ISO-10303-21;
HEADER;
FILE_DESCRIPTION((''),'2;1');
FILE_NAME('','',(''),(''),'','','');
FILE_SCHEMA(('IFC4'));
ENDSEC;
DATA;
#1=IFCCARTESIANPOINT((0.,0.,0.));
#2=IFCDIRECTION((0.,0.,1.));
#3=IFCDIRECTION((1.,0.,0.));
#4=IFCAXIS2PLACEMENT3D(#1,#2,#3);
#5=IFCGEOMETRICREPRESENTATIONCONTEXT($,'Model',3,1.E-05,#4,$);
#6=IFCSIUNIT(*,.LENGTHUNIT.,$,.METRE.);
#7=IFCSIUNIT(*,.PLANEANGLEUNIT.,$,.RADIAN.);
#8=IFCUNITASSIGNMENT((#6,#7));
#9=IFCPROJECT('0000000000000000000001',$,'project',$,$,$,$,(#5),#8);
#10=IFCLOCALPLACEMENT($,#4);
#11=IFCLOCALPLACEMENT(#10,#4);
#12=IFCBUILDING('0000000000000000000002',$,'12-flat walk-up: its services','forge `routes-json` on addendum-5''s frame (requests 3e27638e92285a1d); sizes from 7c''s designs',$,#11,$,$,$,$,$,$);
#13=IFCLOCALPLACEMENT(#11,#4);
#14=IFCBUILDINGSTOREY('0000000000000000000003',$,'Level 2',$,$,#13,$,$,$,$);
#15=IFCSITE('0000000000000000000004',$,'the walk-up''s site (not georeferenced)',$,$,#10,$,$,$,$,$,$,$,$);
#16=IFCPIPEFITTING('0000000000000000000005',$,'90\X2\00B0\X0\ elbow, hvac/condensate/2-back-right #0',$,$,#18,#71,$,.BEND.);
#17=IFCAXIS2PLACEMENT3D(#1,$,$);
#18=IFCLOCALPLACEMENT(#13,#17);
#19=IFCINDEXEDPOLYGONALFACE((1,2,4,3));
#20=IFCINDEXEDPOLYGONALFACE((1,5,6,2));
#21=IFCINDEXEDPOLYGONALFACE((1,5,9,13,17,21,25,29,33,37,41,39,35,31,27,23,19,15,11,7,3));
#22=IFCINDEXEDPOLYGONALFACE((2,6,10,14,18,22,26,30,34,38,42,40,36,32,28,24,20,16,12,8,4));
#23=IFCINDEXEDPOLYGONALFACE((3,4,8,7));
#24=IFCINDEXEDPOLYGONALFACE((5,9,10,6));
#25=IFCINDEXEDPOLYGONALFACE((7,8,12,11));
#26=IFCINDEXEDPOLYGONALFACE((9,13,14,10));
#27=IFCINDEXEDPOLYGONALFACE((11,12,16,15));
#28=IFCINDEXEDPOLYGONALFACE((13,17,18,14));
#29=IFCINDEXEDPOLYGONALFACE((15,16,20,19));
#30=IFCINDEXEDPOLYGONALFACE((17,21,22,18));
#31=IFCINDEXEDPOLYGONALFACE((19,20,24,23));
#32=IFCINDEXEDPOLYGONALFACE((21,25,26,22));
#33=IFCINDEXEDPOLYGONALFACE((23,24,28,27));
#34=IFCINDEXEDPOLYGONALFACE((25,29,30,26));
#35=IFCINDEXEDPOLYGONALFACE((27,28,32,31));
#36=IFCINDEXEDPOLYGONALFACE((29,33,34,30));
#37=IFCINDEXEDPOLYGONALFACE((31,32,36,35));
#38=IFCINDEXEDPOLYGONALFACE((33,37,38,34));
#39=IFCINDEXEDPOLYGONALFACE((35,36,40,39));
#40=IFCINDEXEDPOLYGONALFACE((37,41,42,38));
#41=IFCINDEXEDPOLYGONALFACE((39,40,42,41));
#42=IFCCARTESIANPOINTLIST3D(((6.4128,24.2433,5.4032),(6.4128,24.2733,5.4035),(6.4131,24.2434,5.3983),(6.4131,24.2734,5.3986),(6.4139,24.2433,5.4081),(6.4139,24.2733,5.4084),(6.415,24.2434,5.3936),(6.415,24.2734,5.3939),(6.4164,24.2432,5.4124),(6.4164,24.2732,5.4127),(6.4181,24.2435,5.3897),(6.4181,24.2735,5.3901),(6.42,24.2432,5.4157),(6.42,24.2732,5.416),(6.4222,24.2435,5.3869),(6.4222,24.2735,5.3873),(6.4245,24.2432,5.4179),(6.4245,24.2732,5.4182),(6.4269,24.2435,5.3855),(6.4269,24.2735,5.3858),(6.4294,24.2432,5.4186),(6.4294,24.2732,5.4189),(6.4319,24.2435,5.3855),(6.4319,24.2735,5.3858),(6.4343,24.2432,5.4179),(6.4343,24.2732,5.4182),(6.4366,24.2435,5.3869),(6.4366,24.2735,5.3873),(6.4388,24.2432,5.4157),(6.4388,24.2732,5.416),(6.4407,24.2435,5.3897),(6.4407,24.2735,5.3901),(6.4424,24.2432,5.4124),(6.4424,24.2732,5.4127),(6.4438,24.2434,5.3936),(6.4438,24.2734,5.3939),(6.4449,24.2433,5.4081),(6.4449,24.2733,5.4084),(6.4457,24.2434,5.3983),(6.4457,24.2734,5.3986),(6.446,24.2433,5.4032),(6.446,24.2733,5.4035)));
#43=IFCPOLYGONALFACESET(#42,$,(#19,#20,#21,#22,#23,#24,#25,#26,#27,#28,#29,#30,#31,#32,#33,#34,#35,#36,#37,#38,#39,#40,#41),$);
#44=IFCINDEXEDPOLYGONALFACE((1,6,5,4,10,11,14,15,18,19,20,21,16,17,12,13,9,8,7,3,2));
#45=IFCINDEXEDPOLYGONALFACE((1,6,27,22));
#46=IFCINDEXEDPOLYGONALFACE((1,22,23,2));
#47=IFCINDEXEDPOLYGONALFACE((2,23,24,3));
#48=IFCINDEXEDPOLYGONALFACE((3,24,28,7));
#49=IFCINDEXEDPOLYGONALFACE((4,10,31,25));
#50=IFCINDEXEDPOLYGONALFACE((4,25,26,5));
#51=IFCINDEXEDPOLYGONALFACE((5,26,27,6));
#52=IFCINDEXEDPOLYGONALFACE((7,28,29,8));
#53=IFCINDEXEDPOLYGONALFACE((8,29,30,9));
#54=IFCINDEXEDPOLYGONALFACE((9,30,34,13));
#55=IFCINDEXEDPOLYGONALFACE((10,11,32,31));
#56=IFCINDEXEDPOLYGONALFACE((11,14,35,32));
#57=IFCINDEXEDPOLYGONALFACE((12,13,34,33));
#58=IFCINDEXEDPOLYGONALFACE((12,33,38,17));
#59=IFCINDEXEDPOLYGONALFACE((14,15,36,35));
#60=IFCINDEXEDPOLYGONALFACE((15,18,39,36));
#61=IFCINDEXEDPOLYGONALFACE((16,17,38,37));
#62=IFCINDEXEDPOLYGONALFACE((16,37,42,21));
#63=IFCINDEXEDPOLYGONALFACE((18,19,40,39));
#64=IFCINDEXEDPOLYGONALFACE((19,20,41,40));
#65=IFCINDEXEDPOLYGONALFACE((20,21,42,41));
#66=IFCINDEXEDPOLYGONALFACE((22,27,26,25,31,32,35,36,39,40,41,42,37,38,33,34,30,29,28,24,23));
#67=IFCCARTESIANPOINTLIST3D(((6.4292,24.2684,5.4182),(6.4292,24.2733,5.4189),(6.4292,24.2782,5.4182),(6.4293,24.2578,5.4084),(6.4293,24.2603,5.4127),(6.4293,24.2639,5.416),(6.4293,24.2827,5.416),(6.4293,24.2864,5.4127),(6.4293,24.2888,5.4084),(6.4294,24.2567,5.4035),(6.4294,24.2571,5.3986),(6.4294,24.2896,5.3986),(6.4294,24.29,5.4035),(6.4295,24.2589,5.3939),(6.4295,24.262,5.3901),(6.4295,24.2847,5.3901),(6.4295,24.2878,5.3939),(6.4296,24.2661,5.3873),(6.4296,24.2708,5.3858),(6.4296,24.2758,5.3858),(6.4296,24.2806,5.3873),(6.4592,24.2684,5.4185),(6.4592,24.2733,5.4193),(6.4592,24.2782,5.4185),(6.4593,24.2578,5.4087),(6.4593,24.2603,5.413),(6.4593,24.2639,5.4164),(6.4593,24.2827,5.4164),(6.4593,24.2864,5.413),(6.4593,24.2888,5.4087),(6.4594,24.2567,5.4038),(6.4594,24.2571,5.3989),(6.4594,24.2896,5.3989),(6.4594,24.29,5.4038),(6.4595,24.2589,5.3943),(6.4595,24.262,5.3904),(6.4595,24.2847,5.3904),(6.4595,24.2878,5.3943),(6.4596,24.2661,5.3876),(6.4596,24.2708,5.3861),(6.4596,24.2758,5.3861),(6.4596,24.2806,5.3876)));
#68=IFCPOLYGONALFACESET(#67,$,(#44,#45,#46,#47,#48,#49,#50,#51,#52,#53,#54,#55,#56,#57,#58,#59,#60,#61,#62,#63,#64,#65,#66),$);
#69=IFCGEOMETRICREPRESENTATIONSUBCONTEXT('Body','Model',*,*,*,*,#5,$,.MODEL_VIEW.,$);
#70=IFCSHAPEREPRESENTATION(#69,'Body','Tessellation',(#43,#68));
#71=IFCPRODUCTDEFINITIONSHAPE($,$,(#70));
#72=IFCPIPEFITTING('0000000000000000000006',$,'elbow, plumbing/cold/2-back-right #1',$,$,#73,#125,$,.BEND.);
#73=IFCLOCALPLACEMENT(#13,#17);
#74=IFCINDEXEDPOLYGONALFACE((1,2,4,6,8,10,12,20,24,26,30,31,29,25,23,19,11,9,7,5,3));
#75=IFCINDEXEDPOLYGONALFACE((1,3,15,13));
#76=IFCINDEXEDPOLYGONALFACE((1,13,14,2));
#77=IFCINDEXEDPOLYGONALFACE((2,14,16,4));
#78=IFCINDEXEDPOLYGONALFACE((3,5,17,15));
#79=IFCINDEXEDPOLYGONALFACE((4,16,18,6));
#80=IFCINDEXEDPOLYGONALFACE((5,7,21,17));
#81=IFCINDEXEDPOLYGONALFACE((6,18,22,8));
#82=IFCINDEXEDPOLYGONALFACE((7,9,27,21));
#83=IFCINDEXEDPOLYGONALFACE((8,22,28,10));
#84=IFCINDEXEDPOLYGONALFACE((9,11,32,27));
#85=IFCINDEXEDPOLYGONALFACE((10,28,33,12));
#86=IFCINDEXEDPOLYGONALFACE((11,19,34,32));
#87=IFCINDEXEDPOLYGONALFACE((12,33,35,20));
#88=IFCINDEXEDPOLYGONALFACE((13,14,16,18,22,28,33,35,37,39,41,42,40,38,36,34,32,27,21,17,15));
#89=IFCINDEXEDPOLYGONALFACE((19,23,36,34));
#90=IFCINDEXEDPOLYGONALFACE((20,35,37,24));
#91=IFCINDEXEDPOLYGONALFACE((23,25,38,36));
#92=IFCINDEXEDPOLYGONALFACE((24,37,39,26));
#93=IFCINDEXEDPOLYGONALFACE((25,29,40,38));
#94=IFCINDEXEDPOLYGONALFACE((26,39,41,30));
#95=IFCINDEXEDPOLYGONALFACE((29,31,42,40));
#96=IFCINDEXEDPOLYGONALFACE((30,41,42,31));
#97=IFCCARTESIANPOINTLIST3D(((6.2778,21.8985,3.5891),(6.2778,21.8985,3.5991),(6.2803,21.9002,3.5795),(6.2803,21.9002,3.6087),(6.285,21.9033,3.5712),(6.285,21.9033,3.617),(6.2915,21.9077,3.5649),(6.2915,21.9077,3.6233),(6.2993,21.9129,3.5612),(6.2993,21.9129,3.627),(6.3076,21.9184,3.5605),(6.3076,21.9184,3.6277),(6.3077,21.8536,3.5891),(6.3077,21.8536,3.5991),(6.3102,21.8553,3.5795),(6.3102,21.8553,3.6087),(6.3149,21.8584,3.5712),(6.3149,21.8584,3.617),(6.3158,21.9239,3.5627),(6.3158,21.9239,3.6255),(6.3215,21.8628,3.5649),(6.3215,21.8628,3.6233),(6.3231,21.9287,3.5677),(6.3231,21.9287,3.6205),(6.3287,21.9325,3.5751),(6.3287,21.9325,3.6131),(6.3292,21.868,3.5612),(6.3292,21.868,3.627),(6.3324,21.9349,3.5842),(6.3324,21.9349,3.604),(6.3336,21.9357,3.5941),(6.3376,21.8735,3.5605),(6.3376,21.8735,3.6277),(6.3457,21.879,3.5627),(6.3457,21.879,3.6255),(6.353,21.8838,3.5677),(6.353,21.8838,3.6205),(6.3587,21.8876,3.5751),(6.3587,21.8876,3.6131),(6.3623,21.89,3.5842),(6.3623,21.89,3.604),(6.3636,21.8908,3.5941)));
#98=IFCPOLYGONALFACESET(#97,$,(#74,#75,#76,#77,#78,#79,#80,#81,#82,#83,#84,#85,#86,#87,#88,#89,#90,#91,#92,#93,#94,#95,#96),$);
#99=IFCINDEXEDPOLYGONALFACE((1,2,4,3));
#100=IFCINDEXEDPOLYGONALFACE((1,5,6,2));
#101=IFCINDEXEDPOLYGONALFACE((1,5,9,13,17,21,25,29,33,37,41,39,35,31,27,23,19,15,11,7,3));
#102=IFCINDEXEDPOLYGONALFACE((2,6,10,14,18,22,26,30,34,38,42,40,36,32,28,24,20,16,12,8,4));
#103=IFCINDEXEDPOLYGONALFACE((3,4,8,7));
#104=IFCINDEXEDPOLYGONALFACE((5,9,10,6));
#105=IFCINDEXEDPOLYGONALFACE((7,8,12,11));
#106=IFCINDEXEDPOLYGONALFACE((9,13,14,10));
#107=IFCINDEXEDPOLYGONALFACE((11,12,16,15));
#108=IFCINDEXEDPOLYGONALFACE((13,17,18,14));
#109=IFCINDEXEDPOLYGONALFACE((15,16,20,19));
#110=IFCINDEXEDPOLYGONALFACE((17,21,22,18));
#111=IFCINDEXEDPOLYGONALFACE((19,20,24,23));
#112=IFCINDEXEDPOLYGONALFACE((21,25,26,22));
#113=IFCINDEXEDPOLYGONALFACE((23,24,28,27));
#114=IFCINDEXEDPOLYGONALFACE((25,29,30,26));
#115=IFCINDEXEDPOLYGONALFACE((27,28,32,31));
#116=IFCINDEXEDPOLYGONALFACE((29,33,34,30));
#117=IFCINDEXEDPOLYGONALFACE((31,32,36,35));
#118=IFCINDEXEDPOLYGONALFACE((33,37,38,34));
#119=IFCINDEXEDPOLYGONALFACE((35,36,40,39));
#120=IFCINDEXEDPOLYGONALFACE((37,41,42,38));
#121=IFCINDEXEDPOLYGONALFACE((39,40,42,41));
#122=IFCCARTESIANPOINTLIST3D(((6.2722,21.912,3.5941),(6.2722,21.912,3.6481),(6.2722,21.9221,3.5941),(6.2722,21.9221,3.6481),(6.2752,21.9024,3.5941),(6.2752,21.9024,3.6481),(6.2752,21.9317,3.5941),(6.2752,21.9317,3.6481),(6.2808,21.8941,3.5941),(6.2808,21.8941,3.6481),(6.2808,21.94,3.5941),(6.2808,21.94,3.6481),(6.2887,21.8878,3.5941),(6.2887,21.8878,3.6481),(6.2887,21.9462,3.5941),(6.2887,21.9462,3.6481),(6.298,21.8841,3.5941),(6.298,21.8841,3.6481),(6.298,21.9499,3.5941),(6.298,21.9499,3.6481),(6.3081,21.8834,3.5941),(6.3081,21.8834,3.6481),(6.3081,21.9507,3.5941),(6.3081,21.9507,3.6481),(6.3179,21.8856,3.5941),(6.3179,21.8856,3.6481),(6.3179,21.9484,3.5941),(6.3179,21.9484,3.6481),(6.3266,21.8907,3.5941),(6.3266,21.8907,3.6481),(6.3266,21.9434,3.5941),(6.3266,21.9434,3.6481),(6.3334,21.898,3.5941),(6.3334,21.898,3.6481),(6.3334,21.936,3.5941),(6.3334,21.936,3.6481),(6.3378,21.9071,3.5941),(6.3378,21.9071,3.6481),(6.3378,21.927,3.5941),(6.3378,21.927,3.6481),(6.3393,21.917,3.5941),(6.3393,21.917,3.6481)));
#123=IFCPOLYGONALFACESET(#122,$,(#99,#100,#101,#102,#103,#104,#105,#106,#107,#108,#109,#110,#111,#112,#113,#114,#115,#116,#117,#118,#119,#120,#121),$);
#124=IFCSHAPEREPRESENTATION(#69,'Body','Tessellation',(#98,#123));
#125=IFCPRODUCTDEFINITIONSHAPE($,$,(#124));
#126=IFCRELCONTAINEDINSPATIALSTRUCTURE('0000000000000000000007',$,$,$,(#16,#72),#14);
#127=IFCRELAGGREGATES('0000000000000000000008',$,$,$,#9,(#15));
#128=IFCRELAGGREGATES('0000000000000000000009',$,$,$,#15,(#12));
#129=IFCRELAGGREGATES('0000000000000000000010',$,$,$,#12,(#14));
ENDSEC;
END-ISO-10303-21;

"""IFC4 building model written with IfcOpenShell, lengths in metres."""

from ifc_helpers import new_model, entity, si_unit, frame, origin_with_axes, place, context, subcontext, project, spatial, element, save


model = new_model("IFC4")

# Units and contexts
model_context = context("Model", 3, precision=1e-05, world=origin_with_axes())
body_context = subcontext(model_context, "Body", "Model", "MODEL_VIEW")
ifc_project = project(units=[si_unit("LENGTHUNIT", "METRE"), si_unit("PLANEANGLEUNIT", "RADIAN")], contexts=[model_context])

# Site, building, storey
site_placement = place(None, origin_with_axes())
site = spatial("IfcSite", under=ifc_project, at=site_placement, Name="the walk-up's site (not georeferenced)")
building_placement = place(site_placement, origin_with_axes())
building = spatial("IfcBuilding", under=site, at=building_placement, Name="12-flat walk-up: its services", Description="forge `routes-json` on addendum-5's frame (requests 3e27638e92285a1d); sizes from 7c's designs")
storey_placement = place(building_placement, origin_with_axes())
storey = spatial("IfcBuildingStorey", under=building, at=storey_placement, Name="Level 2")

# Pipe fittings
pipe_fitting_1_placement = place(storey_placement, frame((6.4294, 24.2433, 5.402), z_axis=(0.0, 0.0, 1.0), x_axis=(1.0, 0.0, 0.0)))
element("IfcPipeFitting", 1, at=pipe_fitting_1_placement, inside=storey, Name="90° elbow, hvac/condensate/2-back-right #0", PredefinedType="BEND", context=body_context, shape_type="AdvancedSweptSolid", body=[
    entity("IfcSweptDiskSolid", entity("IfcPolyline", [entity("IfcCartesianPoint", [0.0, 0.0, 0.0]), entity("IfcCartesianPoint", [0.0, 0.03, 0.0003])]), 0.0167),
    entity("IfcSweptDiskSolid", entity("IfcPolyline", [entity("IfcCartesianPoint", [0.0, 0.03, 0.0003]), entity("IfcCartesianPoint", [0.03, 0.03, 0.0006])]), 0.0167),
])
pipe_fitting_2_placement = place(storey_placement, frame((6.3355, 21.8721, 3.5941), z_axis=(0.0, 0.0, 1.0), x_axis=(1.0, 0.0, 0.0)))
element("IfcPipeFitting", 2, at=pipe_fitting_2_placement, inside=storey, Name="elbow, plumbing/cold/2-back-right #1", PredefinedType="BEND", context=body_context, shape_type="AdvancedSweptSolid", body=[
    entity("IfcSweptDiskSolid", entity("IfcPolyline", [entity("IfcCartesianPoint", [0.0, 0.0, 0.0]), entity("IfcCartesianPoint", [-0.0299, 0.0449, 0.0])]), 0.0337),
    entity("IfcSweptDiskSolid", entity("IfcPolyline", [entity("IfcCartesianPoint", [-0.0299, 0.0449, 0.0]), entity("IfcCartesianPoint", [-0.0299, 0.0449, 0.054])]), 0.0337),
])

save(model, "model.ifc")
